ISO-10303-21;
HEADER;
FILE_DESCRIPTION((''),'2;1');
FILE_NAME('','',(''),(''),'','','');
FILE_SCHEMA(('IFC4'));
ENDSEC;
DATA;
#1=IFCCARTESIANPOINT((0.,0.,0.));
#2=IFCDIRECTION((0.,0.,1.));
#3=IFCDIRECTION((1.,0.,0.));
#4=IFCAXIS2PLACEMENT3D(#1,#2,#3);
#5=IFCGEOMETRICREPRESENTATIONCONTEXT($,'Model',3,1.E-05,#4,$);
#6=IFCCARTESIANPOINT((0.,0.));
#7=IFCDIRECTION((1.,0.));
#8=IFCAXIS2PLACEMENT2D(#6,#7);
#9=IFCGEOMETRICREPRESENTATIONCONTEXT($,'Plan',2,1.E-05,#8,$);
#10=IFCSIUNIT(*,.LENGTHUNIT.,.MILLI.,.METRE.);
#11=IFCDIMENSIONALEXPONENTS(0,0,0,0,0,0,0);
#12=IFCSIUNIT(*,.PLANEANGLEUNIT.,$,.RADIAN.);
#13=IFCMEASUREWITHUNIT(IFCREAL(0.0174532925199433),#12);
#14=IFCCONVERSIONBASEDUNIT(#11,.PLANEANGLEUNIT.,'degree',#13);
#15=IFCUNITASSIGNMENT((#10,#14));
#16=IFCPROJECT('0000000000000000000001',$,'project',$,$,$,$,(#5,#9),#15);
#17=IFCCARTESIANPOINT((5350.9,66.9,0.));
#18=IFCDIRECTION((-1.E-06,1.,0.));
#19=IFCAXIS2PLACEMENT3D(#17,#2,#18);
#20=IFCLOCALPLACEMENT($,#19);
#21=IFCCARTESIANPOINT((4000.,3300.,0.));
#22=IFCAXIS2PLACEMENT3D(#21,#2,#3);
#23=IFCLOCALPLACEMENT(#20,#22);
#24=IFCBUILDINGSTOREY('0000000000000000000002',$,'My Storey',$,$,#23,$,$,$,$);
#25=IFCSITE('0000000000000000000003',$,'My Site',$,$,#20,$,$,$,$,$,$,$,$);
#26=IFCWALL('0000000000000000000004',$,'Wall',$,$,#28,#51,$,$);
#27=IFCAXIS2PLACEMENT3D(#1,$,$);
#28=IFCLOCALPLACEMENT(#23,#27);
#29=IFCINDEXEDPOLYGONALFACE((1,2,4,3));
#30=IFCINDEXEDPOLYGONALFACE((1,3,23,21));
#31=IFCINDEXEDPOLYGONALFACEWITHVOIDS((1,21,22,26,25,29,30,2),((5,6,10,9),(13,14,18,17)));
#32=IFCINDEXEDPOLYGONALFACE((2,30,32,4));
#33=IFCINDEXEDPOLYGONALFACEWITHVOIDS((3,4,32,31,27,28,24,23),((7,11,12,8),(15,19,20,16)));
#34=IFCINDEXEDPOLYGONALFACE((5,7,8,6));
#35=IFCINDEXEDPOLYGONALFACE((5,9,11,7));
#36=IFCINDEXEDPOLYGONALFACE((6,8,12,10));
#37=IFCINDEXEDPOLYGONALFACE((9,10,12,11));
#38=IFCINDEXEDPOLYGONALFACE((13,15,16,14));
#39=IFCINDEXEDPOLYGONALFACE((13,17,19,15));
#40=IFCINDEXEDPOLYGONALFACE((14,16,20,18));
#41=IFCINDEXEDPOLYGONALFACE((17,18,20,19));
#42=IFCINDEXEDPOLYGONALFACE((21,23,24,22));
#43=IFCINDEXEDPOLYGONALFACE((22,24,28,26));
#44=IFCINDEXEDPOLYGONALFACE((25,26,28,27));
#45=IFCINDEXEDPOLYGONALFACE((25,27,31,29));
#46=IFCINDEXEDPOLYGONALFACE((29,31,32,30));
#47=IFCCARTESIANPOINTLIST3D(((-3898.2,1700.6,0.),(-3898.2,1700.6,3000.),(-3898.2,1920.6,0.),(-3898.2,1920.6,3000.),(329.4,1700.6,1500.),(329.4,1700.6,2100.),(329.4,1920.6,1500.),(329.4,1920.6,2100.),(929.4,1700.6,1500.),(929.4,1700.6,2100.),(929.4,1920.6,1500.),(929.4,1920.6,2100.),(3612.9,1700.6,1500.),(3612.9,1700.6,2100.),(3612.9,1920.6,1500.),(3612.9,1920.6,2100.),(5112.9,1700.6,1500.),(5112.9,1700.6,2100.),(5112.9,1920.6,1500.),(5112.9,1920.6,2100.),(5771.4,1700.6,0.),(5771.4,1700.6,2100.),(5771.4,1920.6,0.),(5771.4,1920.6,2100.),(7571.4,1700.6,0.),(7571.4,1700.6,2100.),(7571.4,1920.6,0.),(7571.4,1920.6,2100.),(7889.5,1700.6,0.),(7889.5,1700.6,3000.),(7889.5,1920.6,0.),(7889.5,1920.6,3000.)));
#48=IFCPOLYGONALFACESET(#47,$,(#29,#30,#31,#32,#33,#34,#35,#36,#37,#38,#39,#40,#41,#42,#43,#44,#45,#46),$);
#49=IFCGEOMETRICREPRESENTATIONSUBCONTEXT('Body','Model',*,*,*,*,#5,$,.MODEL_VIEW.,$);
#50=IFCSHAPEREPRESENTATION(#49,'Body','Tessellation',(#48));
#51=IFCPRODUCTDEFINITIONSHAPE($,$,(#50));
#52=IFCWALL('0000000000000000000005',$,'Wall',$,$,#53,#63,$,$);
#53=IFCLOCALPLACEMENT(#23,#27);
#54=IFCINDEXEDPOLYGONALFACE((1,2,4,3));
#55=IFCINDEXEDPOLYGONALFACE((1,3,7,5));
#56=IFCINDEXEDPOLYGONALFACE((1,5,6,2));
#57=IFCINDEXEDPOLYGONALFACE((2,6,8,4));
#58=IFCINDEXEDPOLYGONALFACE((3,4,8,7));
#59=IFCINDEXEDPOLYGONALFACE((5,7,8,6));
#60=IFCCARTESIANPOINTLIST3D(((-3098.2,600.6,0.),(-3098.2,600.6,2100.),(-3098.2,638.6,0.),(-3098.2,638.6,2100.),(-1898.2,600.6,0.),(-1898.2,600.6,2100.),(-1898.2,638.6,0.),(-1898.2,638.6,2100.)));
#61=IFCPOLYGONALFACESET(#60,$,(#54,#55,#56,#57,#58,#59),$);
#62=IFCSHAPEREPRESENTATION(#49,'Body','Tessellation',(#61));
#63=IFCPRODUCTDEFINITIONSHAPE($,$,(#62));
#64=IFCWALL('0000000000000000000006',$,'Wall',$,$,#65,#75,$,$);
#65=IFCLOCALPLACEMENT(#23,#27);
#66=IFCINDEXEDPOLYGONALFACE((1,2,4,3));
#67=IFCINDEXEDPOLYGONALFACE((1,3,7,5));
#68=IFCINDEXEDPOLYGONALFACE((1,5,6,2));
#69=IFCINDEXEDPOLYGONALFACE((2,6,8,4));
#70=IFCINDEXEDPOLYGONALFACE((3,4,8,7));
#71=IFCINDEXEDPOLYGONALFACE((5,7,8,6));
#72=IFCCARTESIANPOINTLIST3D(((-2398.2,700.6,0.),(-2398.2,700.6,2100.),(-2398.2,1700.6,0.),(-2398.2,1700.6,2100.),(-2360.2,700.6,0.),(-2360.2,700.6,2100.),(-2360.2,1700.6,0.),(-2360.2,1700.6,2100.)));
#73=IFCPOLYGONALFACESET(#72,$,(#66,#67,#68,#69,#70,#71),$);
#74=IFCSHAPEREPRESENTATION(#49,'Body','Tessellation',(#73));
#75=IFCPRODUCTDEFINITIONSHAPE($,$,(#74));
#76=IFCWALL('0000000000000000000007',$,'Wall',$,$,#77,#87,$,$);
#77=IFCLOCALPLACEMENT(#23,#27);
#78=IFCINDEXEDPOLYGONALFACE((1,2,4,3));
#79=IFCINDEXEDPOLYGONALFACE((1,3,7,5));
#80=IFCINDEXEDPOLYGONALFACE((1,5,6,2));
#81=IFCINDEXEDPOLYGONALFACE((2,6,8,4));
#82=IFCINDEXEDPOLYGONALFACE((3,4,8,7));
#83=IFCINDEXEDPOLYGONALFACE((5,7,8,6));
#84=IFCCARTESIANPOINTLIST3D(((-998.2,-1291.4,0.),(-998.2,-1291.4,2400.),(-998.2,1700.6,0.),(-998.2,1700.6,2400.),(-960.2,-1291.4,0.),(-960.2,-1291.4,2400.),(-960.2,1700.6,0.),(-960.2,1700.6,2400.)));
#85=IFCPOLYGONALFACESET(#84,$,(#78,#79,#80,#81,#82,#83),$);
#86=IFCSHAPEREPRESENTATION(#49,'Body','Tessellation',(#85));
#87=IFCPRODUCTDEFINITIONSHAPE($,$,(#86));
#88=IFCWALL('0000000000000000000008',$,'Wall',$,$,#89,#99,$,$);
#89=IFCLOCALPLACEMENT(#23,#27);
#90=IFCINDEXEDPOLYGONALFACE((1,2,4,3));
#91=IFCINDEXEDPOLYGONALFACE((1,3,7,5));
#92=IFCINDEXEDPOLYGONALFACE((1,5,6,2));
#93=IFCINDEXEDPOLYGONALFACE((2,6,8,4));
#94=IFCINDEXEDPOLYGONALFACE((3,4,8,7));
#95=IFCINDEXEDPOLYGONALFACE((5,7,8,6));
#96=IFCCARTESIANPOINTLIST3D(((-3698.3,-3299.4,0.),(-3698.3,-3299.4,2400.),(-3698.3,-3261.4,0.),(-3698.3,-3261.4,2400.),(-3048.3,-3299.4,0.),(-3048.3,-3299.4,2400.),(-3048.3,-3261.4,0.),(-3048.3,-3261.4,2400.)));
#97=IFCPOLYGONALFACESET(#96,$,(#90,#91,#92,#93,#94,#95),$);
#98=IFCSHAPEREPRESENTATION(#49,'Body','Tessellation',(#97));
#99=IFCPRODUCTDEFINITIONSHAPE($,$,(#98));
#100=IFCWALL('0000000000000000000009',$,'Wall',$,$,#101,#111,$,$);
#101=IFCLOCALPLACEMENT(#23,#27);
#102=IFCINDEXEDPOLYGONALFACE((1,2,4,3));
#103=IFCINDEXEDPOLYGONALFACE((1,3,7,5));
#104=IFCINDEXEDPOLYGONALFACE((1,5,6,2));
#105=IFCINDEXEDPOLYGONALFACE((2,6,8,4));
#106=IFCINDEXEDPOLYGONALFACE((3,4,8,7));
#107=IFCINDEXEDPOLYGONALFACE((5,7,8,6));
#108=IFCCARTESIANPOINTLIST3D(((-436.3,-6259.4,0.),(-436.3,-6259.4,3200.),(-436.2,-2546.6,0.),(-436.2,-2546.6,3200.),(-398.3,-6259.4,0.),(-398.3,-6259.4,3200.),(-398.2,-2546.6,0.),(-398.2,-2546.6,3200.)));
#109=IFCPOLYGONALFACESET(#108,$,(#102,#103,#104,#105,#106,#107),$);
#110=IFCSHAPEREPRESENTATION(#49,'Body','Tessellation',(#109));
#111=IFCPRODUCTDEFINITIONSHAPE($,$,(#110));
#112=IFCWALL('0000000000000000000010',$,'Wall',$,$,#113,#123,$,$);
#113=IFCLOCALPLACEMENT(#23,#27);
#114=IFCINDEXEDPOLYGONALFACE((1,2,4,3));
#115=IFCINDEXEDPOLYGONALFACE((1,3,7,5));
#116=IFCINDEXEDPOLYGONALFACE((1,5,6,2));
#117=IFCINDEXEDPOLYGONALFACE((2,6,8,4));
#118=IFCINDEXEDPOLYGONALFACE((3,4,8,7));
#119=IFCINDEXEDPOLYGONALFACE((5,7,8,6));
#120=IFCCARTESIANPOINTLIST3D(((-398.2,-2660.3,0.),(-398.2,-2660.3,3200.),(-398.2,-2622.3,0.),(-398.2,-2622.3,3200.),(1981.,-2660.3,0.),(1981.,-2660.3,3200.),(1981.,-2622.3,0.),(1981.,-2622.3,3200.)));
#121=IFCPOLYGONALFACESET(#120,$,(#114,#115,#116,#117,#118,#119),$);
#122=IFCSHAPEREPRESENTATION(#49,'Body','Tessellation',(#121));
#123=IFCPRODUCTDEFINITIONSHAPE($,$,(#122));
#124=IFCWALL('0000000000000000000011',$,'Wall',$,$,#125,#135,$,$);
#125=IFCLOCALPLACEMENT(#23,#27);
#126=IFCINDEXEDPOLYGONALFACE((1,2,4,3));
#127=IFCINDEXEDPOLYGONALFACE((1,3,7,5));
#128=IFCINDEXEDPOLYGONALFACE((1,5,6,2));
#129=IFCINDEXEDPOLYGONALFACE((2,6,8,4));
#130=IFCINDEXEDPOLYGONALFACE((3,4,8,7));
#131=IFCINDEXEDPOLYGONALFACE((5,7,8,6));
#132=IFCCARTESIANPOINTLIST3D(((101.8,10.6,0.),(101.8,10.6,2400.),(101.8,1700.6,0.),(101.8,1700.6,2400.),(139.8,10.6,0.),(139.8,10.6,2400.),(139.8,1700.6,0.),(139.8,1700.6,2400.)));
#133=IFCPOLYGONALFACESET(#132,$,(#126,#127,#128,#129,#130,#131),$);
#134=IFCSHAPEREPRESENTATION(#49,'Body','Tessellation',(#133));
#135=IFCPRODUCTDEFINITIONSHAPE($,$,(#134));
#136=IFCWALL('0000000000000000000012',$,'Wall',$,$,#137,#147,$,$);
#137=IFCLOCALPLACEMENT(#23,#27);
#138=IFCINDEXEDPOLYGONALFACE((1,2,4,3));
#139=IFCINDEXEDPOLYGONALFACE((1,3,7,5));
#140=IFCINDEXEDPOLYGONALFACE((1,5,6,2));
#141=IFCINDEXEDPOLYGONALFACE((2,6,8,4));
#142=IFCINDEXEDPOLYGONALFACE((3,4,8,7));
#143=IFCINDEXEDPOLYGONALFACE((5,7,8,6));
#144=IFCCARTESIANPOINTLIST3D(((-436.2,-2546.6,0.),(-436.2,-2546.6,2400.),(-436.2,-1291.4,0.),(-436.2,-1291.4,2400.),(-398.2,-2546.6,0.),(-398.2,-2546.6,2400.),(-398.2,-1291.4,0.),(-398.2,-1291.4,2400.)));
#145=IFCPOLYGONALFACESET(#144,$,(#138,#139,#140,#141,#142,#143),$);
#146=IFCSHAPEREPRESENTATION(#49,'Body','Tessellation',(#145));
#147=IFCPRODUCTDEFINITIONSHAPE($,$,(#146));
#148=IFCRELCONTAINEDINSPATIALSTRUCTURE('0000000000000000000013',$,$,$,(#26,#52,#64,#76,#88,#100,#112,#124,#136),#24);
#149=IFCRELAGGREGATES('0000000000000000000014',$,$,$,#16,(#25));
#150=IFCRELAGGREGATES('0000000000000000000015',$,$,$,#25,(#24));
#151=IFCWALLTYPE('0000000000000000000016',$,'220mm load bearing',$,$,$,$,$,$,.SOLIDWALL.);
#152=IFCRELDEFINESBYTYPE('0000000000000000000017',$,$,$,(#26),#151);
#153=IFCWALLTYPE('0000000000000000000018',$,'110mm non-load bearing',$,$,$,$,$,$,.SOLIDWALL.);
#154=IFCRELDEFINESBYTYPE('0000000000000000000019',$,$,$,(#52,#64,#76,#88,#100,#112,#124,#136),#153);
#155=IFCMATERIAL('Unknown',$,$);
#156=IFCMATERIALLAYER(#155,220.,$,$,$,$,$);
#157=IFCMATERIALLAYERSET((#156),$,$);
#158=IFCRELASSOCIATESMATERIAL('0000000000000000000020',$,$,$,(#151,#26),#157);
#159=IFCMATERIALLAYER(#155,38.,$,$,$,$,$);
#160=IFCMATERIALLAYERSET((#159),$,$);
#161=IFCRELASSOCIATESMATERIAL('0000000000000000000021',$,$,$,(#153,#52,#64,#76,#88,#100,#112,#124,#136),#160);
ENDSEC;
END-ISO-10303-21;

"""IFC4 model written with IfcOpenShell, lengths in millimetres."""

from ifc_helpers import new_model, entity, si_unit, converted_unit, frame, origin_with_axes, origin_2d_with_axis, place, context, subcontext, project, spatial, line, indexed_curve, outline, extrude, source, transform, mapped, material, layer, layer_set, layer_usage, type_object, element, save


model = new_model("IFC4")

# Units and contexts
model_context = context("Model", 3, precision=1e-05, world=origin_with_axes())
plan_context = context("Plan", 2, precision=1e-05, world=origin_2d_with_axis())
body_context = subcontext(model_context, "Body", "Model", "MODEL_VIEW")
ifc_project = project(units=[si_unit("LENGTHUNIT", "METRE", prefix="MILLI"), converted_unit("PLANEANGLEUNIT", "degree", entity("IfcReal", 0.0174532925199433), si_unit("PLANEANGLEUNIT", "RADIAN"), dimensions=[0, 0, 0, 0, 0, 0, 0])], contexts=[model_context, plan_context])

# Site, storey
site_placement = place(None, frame((5350.9, 66.9, 0.0), z_axis=(0.0, 0.0, 1.0), x_axis=(-0.000001, 1.0, 0.0)))
site = spatial("IfcSite", under=ifc_project, at=site_placement, Name="My Site")
storey_placement = place(site_placement, frame((4000.0, 3300.0, 0.0), z_axis=(0.0, 0.0, 1.0), x_axis=(1.0, 0.0, 0.0)))
storey = spatial("IfcBuildingStorey", under=site, at=storey_placement, Name="My Storey")

# Shared definitions
ifc_material = material(Name="Unknown")

# Shared definitions
ifc_layer_1 = layer(ifc_material, 220.0)
ifc_layer_set_1 = layer_set([ifc_layer_1])
wall_type_1 = type_object("IfcWallType", Name="220mm load bearing", PredefinedType="SOLIDWALL", material=ifc_layer_set_1)
shared_shape_1 = source(origin_with_axes(), body_context, "Body", "SweptSolid", [
    extrude(outline(indexed_curve([(0.0, 0.0), (1500.0, 0.0), (1500.0, 600.0), (0.0, 600.0)], segments=[line(1, 2, 3, 4, 1)])), frame((0.0, -100.0, 0.0), z_axis=(0.0, -1.0, 0.0), x_axis=(1.0, 0.0, 0.0)), (0.0, 0.0, -1.0), 420.0),
])

# Wall, openings
ifc_layer_usage_1 = layer_usage(ifc_layer_set_1, "AXIS2", "POSITIVE", 0.0)
wall_1_placement = place(storey_placement, frame((-3898.2, 1700.6, 0.0), z_axis=(0.0, 0.0, 1.0), x_axis=(1.0, 0.0, 0.0)))
wall_1 = element("IfcWall", 1, at=wall_1_placement, inside=storey, type_object=wall_type_1, material=ifc_layer_usage_1, Name="Wall", context=body_context, shape_type="SweptSolid", body=[
    extrude(outline(indexed_curve([(0.0, 0.0), (0.0, 220.0), (11787.7, 220.0), (11787.7, 0.0), (0.0, 0.0)], self_intersect=False)), origin_with_axes(), (0.0, 0.0, 1.0), 3000.0),
])
shared_shape_2 = source(origin_with_axes(), body_context, "Body", "SweptSolid", [
    extrude(outline(indexed_curve([(0.0, 0.0), (1800.0, 0.0), (1800.0, 2100.0), (0.0, 2100.0)], segments=[line(1, 2, 3, 4, 1)])), frame((0.0, -600.0, 0.0), z_axis=(0.0, -1.0, 0.0), x_axis=(1.0, 0.0, 0.0)), (0.0, 0.0, -1.0), 1200.0),
])
opening_1_placement = place(wall_1_placement, frame((9669.6, 0.0, 0.0), z_axis=(0.0, 0.0, 1.0), x_axis=(1.0, 0.0, 0.0)))
element("IfcOpeningElement", 2, at=opening_1_placement, cuts=wall_1, PredefinedType="OPENING", context=body_context, shape_type="MappedRepresentation", body=[
    mapped(shared_shape_2, transform((0.0, 0.0, 0.0), x_axis=(1.0, 0.0, 0.0), y_axis=(0.0, 1.0, 0.0), z_axis=(0.0, 0.0, 1.0), scale=1.0)),
])
opening_2_placement = place(wall_1_placement, frame((7511.1, 0.0, 1500.0), z_axis=(0.0, 0.0, 1.0), x_axis=(1.0, 0.0, 0.0)))
element("IfcOpeningElement", 3, at=opening_2_placement, cuts=wall_1, PredefinedType="OPENING", context=body_context, shape_type="MappedRepresentation", body=[
    mapped(shared_shape_1, transform((0.0, 0.0, 0.0), x_axis=(1.0, 0.0, 0.0), y_axis=(0.0, 1.0, 0.0), z_axis=(0.0, 0.0, 1.0), scale=1.0)),
])
shared_shape_3 = source(origin_with_axes(), body_context, "Body", "SweptSolid", [
    extrude(outline(indexed_curve([(0.0, 0.0), (600.0, 0.0), (600.0, 600.0), (0.0, 600.0)], segments=[line(1, 2, 3, 4, 1)])), frame((0.0, -600.0, 0.0), z_axis=(0.0, -1.0, 0.0), x_axis=(1.0, 0.0, 0.0)), (0.0, 0.0, -1.0), 1200.0),
])
opening_3_placement = place(wall_1_placement, frame((4227.6, 0.0, 1500.0), z_axis=(0.0, 0.0, 1.0), x_axis=(1.0, 0.0, 0.0)))
element("IfcOpeningElement", 4, at=opening_3_placement, cuts=wall_1, PredefinedType="OPENING", context=body_context, shape_type="MappedRepresentation", body=[
    mapped(shared_shape_3, transform((0.0, 0.0, 0.0), x_axis=(1.0, 0.0, 0.0), y_axis=(0.0, 1.0, 0.0), z_axis=(0.0, 0.0, 1.0), scale=1.0)),
])

# Walls
ifc_layer_2 = layer(ifc_material, 38.0)
ifc_layer_set_2 = layer_set([ifc_layer_2])
ifc_layer_usage_2 = layer_usage(ifc_layer_set_2, "AXIS2", "POSITIVE", 0.0)
wall_type_2 = type_object("IfcWallType", Name="110mm non-load bearing", PredefinedType="SOLIDWALL", material=ifc_layer_set_2)
wall_2_placement = place(storey_placement, frame((-3098.2, 600.6, 0.0), z_axis=(0.0, 0.0, 1.0), x_axis=(1.0, -0.000001, 0.0)))
element("IfcWall", 5, at=wall_2_placement, inside=storey, type_object=wall_type_2, material=ifc_layer_usage_2, Name="Wall", context=body_context, shape_type="SweptSolid", body=[
    extrude(outline(indexed_curve([(0.0, 0.0), (0.0, 38.0), (1200.0, 38.0), (1200.0, 0.0), (0.0, 0.0)], self_intersect=False)), origin_with_axes(), (0.0, 0.0, 1.0), 2100.0),
])
ifc_layer_usage_3 = layer_usage(ifc_layer_set_2, "AXIS2", "POSITIVE", 0.0)
wall_3_placement = place(storey_placement, frame((-2398.2, 1700.6, 0.0), z_axis=(0.0, 0.0, 1.0), x_axis=(0.0, -1.0, 0.0)))
element("IfcWall", 6, at=wall_3_placement, inside=storey, type_object=wall_type_2, material=ifc_layer_usage_3, Name="Wall", context=body_context, shape_type="SweptSolid", body=[
    extrude(outline(indexed_curve([(0.0, 0.0), (0.0, 38.0), (1000.0, 38.0), (1000.0, 0.0), (0.0, 0.0)], self_intersect=False)), origin_with_axes(), (0.0, 0.0, 1.0), 2100.0),
])
ifc_layer_usage_4 = layer_usage(ifc_layer_set_2, "AXIS2", "POSITIVE", 0.0)
wall_4_placement = place(storey_placement, frame((-998.2, 1700.6, 0.0), z_axis=(0.0, 0.0, 1.0), x_axis=(0.0, -1.0, 0.0)))
element("IfcWall", 7, at=wall_4_placement, inside=storey, type_object=wall_type_2, material=ifc_layer_usage_4, Name="Wall", context=body_context, shape_type="SweptSolid", body=[
    extrude(outline(indexed_curve([(0.0, 0.0), (0.0, 38.0), (2992.0, 38.0), (2992.0, 0.0), (0.0, 0.0)], self_intersect=False)), origin_with_axes(), (0.0, 0.0, 1.0), 2400.0),
])
ifc_layer_usage_5 = layer_usage(ifc_layer_set_2, "AXIS2", "POSITIVE", 0.0)
wall_5_placement = place(storey_placement, frame((-3698.3, -3299.4, 0.0), z_axis=(0.0, 0.0, 1.0), x_axis=(1.0, 0.0, 0.0)))
element("IfcWall", 8, at=wall_5_placement, inside=storey, type_object=wall_type_2, material=ifc_layer_usage_5, Name="Wall", context=body_context, shape_type="SweptSolid", body=[
    extrude(outline(indexed_curve([(0.0, 0.0), (0.0, 38.0), (650.0, 38.0), (650.0, 0.0), (0.0, 0.0)], self_intersect=False)), origin_with_axes(), (0.0, 0.0, 1.0), 2400.0),
])
ifc_layer_usage_6 = layer_usage(ifc_layer_set_2, "AXIS2", "POSITIVE", 0.0)
wall_6_placement = place(storey_placement, frame((-398.3, -6259.4, 0.0), z_axis=(0.0, 0.0, 1.0), x_axis=(0.000001, 1.0, 0.0)))
element("IfcWall", 9, at=wall_6_placement, inside=storey, type_object=wall_type_2, material=ifc_layer_usage_6, Name="Wall", context=body_context, shape_type="SweptSolid", body=[
    extrude(outline(indexed_curve([(0.0, 0.0), (0.0, 38.0), (3712.8, 38.0), (3712.8, 0.0), (0.0, 0.0)], self_intersect=False)), origin_with_axes(), (0.0, 0.0, 1.0), 3200.0),
])
ifc_layer_usage_7 = layer_usage(ifc_layer_set_2, "AXIS2", "POSITIVE", 0.0)
wall_7_placement = place(storey_placement, frame((-398.2, -2660.3, 0.0), z_axis=(0.0, 0.0, 1.0), x_axis=(1.0, 0.0, 0.0)))
element("IfcWall", 10, at=wall_7_placement, inside=storey, type_object=wall_type_2, material=ifc_layer_usage_7, Name="Wall", context=body_context, shape_type="SweptSolid", body=[
    extrude(outline(indexed_curve([(0.0, 0.0), (0.0, 38.0), (2379.3, 38.0), (2379.3, 0.0), (0.0, 0.0)], self_intersect=False)), origin_with_axes(), (0.0, 0.0, 1.0), 3200.0),
])
ifc_layer_usage_8 = layer_usage(ifc_layer_set_2, "AXIS2", "POSITIVE", 0.0)
wall_8_placement = place(storey_placement, frame((101.8, 1700.6, 0.0), z_axis=(0.0, 0.0, 1.0), x_axis=(-0.000001, -1.0, 0.0)))
element("IfcWall", 11, at=wall_8_placement, inside=storey, type_object=wall_type_2, material=ifc_layer_usage_8, Name="Wall", context=body_context, shape_type="SweptSolid", body=[
    extrude(outline(indexed_curve([(0.0, 0.0), (0.0, 38.0), (1690.0, 38.0), (1690.0, 0.0), (0.0, 0.0)], self_intersect=False)), origin_with_axes(), (0.0, 0.0, 1.0), 2400.0),
])
ifc_layer_usage_9 = layer_usage(ifc_layer_set_2, "AXIS2", "POSITIVE", 0.0)
wall_9_placement = place(storey_placement, frame((-398.2, -2546.6, 0.0), z_axis=(0.0, 0.0, 1.0), x_axis=(0.000001, 1.0, 0.0)))
element("IfcWall", 12, at=wall_9_placement, inside=storey, type_object=wall_type_2, material=ifc_layer_usage_9, Name="Wall", context=body_context, shape_type="SweptSolid", body=[
    extrude(outline(indexed_curve([(0.0, 0.0), (0.0, 38.0), (1255.1, 38.0), (1255.1, 0.0), (0.0, 0.0)], self_intersect=False)), origin_with_axes(), (0.0, 0.0, 1.0), 2400.0),
])

save(model, "model.ifc")
